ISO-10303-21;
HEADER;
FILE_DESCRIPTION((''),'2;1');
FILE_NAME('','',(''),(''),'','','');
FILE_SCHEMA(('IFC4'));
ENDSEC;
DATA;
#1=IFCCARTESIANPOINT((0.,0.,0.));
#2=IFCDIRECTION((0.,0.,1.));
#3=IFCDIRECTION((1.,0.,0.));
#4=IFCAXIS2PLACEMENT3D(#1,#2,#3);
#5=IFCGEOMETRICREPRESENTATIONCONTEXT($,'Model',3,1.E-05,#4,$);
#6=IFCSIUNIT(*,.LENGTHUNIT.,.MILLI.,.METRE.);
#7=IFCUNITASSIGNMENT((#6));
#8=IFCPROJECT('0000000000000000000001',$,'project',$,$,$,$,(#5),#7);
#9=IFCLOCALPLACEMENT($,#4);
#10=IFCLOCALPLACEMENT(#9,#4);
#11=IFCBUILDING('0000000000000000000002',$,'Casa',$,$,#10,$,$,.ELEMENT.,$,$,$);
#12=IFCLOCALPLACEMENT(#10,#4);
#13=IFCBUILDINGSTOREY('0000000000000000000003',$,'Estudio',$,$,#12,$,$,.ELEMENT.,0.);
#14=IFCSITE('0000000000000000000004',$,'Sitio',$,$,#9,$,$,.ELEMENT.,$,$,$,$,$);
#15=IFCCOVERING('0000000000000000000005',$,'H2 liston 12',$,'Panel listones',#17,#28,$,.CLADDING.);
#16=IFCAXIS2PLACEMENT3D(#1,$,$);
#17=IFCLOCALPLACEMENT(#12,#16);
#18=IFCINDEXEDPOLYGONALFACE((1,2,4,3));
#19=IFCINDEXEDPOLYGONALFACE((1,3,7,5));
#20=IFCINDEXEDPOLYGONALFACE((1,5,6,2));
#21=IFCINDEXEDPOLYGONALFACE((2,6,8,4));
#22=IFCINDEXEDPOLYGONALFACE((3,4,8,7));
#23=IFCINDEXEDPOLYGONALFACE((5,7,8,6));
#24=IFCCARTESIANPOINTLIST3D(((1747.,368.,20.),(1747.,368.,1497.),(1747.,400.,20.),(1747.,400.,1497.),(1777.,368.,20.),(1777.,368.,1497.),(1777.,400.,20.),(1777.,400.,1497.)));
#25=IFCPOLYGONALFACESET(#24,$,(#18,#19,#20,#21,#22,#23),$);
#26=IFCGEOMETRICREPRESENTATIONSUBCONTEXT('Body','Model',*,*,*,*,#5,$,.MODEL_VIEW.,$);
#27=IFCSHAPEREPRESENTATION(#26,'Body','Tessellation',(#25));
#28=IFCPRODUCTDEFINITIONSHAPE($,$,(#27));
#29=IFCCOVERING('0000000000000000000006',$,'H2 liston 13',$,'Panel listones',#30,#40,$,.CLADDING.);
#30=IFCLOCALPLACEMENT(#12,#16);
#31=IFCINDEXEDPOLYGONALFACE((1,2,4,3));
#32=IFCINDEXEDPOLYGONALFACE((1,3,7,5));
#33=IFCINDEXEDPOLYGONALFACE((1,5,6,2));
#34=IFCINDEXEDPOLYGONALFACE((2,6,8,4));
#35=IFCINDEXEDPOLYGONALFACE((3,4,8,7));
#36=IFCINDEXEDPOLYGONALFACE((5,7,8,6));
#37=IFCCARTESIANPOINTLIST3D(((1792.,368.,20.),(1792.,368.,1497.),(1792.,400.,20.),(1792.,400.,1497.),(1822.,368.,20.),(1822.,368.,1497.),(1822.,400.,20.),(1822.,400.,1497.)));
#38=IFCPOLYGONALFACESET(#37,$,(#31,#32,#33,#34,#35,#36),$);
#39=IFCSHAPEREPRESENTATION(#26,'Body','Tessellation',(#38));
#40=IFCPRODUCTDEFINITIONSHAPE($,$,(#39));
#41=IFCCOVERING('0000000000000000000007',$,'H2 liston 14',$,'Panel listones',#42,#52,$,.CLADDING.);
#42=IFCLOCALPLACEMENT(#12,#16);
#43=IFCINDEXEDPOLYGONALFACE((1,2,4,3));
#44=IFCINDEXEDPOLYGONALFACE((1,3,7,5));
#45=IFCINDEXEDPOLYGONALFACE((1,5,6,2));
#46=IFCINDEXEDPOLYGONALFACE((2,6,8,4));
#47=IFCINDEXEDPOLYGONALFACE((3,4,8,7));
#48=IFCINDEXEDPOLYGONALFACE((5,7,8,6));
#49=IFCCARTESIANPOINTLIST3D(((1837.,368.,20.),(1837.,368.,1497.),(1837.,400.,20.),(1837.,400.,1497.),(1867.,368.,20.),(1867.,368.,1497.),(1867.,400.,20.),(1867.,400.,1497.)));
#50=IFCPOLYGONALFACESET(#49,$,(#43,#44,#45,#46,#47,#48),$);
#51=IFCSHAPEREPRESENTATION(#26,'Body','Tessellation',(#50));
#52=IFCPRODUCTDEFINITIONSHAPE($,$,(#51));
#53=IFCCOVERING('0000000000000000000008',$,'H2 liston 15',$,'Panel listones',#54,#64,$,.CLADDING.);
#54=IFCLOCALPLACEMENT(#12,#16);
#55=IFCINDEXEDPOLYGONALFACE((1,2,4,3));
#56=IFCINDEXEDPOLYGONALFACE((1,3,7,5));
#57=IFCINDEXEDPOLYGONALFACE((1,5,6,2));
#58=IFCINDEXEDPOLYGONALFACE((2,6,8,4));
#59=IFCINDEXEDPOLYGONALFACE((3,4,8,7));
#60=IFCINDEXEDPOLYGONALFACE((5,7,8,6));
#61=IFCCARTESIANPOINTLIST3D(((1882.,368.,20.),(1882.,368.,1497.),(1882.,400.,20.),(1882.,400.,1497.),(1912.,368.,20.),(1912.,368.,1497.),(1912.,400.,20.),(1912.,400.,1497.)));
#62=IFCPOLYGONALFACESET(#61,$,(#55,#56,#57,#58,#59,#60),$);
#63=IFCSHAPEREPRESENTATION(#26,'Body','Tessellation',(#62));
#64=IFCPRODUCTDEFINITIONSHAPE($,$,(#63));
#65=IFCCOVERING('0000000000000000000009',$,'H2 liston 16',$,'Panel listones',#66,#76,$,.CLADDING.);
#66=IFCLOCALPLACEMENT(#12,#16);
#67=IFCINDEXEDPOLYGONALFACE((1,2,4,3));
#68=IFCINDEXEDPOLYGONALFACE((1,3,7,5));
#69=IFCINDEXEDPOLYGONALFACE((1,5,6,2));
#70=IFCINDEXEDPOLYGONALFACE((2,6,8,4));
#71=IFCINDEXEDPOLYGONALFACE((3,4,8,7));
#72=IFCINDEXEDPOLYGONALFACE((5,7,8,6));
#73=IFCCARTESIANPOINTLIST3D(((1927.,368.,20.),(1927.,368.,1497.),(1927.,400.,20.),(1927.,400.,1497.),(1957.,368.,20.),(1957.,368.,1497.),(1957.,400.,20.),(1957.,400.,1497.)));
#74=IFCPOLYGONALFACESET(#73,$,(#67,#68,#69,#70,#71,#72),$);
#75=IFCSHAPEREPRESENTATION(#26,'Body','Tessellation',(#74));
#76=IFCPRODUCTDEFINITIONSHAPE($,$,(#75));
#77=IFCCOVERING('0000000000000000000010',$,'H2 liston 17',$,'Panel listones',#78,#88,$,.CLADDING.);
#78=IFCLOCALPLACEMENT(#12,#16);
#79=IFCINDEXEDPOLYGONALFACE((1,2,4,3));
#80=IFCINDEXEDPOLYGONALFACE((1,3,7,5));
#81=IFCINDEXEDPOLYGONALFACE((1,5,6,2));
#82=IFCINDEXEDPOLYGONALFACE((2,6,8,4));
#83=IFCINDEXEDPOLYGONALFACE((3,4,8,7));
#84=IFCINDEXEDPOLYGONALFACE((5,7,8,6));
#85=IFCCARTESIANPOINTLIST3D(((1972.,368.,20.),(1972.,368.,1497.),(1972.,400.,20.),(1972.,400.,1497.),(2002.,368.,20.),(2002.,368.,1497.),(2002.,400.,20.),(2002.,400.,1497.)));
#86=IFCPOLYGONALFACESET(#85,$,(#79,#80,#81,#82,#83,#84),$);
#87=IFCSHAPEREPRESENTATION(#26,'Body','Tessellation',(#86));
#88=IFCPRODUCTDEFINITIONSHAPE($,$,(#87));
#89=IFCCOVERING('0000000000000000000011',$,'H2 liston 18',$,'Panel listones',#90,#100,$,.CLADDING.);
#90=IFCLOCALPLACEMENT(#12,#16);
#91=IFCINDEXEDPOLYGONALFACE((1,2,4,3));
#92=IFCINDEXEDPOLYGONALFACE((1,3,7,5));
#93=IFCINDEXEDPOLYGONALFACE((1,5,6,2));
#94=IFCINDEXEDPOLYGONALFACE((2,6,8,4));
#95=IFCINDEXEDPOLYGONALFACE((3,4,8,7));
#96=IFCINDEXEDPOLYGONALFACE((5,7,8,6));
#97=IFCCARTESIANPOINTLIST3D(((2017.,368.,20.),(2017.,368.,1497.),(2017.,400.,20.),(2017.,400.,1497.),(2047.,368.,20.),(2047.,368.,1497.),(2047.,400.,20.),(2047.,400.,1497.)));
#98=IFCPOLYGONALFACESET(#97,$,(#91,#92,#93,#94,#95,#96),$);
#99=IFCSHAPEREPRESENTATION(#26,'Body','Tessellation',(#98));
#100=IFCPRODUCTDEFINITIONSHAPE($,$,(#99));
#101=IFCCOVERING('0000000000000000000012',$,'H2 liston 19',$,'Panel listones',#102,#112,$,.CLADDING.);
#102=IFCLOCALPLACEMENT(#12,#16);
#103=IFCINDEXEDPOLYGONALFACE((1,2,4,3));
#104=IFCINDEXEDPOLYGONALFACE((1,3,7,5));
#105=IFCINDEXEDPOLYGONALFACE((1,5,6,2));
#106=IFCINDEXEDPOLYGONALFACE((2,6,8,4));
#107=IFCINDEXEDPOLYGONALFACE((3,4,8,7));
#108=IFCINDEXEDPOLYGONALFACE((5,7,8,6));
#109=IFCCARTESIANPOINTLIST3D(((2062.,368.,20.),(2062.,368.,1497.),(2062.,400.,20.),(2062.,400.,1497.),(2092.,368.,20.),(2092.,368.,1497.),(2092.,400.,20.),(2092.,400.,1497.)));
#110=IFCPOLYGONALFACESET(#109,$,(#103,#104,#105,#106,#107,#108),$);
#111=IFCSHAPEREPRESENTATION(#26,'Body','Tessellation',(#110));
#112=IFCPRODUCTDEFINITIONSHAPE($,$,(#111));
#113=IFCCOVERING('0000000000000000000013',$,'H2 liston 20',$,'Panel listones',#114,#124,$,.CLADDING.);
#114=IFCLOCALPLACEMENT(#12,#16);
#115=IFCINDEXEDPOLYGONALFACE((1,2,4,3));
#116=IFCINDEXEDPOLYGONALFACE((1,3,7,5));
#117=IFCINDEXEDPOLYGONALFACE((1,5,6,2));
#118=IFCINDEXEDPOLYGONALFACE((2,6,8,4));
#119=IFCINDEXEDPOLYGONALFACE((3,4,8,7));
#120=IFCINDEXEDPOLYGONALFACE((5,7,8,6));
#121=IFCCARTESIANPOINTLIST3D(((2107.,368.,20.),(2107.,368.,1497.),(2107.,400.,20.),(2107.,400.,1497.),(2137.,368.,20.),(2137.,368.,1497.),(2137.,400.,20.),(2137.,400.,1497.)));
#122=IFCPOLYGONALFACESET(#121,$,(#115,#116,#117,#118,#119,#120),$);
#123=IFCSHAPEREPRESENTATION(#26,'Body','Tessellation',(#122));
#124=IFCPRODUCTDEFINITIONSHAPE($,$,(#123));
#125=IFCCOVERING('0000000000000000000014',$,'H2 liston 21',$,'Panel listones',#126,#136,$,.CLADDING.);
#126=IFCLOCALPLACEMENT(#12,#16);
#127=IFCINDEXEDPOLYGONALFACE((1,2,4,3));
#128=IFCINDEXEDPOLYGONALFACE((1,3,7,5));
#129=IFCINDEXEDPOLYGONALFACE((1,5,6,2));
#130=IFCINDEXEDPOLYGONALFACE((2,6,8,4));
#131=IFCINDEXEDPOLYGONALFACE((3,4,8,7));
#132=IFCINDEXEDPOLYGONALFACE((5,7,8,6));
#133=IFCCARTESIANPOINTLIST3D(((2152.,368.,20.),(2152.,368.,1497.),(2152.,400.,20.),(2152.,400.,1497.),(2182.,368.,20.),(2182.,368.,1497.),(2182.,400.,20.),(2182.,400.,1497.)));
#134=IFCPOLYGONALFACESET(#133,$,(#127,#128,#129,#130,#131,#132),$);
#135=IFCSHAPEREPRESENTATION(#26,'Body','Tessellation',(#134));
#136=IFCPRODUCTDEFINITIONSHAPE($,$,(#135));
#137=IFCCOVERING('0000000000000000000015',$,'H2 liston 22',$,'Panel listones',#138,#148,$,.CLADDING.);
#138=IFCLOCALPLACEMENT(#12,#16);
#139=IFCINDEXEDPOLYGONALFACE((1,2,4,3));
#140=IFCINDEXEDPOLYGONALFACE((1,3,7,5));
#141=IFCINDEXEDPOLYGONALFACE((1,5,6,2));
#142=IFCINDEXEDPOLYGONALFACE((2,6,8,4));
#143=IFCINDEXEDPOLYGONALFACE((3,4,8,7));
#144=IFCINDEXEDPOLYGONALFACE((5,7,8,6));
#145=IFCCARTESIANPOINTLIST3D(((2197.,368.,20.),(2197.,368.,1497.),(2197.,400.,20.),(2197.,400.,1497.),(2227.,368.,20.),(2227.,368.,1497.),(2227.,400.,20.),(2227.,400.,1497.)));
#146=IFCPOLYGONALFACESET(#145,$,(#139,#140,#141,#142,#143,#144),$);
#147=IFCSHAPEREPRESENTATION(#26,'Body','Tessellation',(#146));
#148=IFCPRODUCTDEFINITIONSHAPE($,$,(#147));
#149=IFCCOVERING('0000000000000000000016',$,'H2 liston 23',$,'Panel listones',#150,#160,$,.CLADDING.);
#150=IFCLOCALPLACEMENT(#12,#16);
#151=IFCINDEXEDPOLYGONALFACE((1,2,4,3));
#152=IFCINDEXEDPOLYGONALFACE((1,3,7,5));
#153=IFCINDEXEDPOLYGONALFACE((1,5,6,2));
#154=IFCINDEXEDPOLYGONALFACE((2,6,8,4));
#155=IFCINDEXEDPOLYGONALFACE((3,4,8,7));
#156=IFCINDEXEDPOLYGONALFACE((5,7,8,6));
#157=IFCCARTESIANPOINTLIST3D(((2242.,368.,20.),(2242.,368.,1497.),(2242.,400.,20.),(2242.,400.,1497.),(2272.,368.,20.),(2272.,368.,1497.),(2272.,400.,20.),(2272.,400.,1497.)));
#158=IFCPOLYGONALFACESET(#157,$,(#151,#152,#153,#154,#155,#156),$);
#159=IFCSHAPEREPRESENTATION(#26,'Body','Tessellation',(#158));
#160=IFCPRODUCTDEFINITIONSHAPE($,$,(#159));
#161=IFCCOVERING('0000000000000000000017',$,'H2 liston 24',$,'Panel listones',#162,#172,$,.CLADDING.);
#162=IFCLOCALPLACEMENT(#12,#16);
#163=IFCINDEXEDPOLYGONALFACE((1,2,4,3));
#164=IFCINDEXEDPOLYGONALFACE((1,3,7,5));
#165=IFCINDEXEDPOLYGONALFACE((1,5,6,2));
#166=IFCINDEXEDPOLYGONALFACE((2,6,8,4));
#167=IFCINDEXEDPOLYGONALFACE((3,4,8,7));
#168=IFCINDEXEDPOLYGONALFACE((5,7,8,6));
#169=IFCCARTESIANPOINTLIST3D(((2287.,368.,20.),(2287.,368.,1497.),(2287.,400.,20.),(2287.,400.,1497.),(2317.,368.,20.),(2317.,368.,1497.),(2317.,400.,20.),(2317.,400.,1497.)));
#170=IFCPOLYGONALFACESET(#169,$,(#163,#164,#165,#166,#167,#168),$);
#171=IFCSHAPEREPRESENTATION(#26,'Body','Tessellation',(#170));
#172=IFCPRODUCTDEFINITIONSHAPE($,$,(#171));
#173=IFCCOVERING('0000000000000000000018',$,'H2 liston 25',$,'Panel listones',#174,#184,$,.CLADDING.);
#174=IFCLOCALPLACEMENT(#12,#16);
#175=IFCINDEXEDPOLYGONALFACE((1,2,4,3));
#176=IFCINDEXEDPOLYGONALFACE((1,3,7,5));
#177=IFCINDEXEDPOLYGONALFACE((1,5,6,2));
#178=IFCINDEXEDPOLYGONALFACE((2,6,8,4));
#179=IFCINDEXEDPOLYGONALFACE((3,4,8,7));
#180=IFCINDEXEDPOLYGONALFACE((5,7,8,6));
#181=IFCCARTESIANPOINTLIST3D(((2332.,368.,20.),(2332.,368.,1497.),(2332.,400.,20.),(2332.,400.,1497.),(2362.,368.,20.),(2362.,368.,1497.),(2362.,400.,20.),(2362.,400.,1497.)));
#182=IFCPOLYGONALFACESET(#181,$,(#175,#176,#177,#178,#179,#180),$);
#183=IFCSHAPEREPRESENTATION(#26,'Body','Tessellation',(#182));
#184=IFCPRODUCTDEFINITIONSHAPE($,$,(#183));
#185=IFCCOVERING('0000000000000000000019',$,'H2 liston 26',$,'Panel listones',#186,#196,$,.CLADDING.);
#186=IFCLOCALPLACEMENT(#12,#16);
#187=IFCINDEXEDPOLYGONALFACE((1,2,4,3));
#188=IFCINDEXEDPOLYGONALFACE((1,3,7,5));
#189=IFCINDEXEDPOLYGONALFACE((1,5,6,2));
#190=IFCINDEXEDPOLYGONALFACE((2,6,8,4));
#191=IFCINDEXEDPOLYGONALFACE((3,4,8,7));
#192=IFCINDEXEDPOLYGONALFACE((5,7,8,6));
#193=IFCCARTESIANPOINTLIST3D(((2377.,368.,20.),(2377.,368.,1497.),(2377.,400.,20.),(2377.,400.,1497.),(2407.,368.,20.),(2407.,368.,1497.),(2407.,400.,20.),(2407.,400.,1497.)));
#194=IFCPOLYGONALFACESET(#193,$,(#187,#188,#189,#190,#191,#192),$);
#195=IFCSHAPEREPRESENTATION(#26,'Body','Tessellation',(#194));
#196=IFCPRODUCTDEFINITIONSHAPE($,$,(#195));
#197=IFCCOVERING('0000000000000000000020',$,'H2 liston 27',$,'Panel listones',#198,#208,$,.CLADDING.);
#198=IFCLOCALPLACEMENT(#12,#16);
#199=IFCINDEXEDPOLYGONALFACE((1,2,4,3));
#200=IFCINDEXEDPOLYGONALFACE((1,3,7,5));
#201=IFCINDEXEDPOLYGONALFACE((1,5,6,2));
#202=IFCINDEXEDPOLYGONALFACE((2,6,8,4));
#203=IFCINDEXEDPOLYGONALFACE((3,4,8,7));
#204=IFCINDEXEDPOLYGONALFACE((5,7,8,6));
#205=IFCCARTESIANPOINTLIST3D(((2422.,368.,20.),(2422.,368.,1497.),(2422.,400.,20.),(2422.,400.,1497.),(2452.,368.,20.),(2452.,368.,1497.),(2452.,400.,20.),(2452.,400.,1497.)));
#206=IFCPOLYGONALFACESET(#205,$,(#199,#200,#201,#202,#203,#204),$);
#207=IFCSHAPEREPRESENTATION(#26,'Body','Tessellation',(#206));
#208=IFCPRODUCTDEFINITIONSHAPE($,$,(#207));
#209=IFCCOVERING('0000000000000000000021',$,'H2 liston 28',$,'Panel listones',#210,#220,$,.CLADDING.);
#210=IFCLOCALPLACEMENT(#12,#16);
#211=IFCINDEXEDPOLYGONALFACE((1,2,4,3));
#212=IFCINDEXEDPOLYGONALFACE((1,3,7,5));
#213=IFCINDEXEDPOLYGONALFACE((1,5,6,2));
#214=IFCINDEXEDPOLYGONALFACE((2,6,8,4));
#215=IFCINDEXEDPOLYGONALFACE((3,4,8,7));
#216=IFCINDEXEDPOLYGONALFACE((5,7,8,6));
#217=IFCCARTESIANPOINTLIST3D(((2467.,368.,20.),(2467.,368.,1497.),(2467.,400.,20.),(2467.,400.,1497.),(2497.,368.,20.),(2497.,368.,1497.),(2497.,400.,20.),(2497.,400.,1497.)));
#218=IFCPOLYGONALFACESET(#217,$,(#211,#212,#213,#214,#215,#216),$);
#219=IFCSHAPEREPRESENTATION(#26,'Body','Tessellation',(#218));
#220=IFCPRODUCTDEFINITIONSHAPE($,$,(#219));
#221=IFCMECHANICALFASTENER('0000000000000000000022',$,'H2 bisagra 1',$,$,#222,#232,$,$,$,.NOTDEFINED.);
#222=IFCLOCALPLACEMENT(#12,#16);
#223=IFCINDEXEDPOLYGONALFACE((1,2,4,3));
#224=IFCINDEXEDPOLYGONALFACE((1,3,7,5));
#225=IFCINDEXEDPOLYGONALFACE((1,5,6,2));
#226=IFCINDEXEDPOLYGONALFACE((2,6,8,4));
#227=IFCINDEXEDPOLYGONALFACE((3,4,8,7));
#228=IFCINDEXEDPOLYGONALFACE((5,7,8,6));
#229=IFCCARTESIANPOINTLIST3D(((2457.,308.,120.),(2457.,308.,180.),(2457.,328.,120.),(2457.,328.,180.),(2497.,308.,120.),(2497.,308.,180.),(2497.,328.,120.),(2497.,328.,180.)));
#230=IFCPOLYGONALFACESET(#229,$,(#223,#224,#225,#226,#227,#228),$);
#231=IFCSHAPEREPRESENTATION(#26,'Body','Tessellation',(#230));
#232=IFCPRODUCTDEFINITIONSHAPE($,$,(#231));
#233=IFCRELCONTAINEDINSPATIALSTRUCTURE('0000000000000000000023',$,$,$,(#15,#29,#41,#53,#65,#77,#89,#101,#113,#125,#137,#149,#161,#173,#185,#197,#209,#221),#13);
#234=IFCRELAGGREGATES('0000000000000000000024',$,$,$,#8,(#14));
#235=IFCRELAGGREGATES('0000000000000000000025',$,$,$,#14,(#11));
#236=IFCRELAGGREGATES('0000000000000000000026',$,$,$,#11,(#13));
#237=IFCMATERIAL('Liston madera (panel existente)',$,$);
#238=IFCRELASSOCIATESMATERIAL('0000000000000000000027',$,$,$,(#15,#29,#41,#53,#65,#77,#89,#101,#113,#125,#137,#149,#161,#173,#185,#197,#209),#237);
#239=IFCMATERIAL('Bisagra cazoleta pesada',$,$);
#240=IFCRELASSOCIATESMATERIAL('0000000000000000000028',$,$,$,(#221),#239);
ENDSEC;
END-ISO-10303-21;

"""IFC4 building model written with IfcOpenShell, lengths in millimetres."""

from ifc_helpers import new_model, si_unit, frame, frame_2d, origin_with_axes, place, context, subcontext, project, spatial, rectangle, extrude, material, element, save


model = new_model("IFC4")

# Units and contexts
model_context = context("Model", 3, precision=1e-05, world=origin_with_axes())
body_context = subcontext(model_context, "Body", "Model", "MODEL_VIEW")
ifc_project = project(units=[si_unit("LENGTHUNIT", "METRE", prefix="MILLI")], contexts=[model_context])

# Site, building, storey
site_placement = place(None, origin_with_axes())
site = spatial("IfcSite", under=ifc_project, at=site_placement, Name="Sitio", CompositionType="ELEMENT")
building_placement = place(site_placement, origin_with_axes())
building = spatial("IfcBuilding", under=site, at=building_placement, Name="Casa", CompositionType="ELEMENT")
storey_placement = place(building_placement, origin_with_axes())
storey = spatial("IfcBuildingStorey", under=building, at=storey_placement, Name="Estudio", CompositionType="ELEMENT", Elevation=0.0)

# Coverings
ifc_material_1 = material(Name="Liston madera (panel existente)")
for number, where, z_axis, x_axis, name in (
    (1, (1747.0, 368.0, 20.0), (0.0, 0.0, 1.0), (1.0, 0.0, 0.0), "H2 liston 12"),
    (2, (1792.0, 368.0, 20.0), (0.0, 0.0, 1.0), (1.0, 0.0, 0.0), "H2 liston 13"),
    (3, (1837.0, 368.0, 20.0), (0.0, 0.0, 1.0), (1.0, 0.0, 0.0), "H2 liston 14"),
    (4, (1882.0, 368.0, 20.0), (0.0, 0.0, 1.0), (1.0, 0.0, 0.0), "H2 liston 15"),
    (5, (1927.0, 368.0, 20.0), (0.0, 0.0, 1.0), (1.0, 0.0, 0.0), "H2 liston 16"),
    (6, (1972.0, 368.0, 20.0), (0.0, 0.0, 1.0), (1.0, 0.0, 0.0), "H2 liston 17"),
    (7, (2017.0, 368.0, 20.0), (0.0, 0.0, 1.0), (1.0, 0.0, 0.0), "H2 liston 18"),
    (8, (2062.0, 368.0, 20.0), (0.0, 0.0, 1.0), (1.0, 0.0, 0.0), "H2 liston 19"),
    (9, (2107.0, 368.0, 20.0), (0.0, 0.0, 1.0), (1.0, 0.0, 0.0), "H2 liston 20"),
    (10, (2152.0, 368.0, 20.0), (0.0, 0.0, 1.0), (1.0, 0.0, 0.0), "H2 liston 21"),
    (11, (2197.0, 368.0, 20.0), (0.0, 0.0, 1.0), (1.0, 0.0, 0.0), "H2 liston 22"),
    (12, (2242.0, 368.0, 20.0), (0.0, 0.0, 1.0), (1.0, 0.0, 0.0), "H2 liston 23"),
    (13, (2287.0, 368.0, 20.0), (0.0, 0.0, 1.0), (1.0, 0.0, 0.0), "H2 liston 24"),
    (14, (2332.0, 368.0, 20.0), (0.0, 0.0, 1.0), (1.0, 0.0, 0.0), "H2 liston 25"),
    (15, (2377.0, 368.0, 20.0), (0.0, 0.0, 1.0), (1.0, 0.0, 0.0), "H2 liston 26"),
    (16, (2422.0, 368.0, 20.0), (0.0, 0.0, 1.0), (1.0, 0.0, 0.0), "H2 liston 27"),
    (17, (2467.0, 368.0, 20.0), (0.0, 0.0, 1.0), (1.0, 0.0, 0.0), "H2 liston 28"),
):
    element("IfcCovering", number, at=place(storey_placement, frame(where, z_axis=z_axis, x_axis=x_axis)), inside=storey, material=ifc_material_1, Name=name, ObjectType="Panel listones", PredefinedType="CLADDING", context=body_context, shape_type="SweptSolid", body=[
        extrude(rectangle(XDim=30.0, YDim=32.0, at=frame_2d((15.0, 16.0))), origin_with_axes(), (0.0, 0.0, 1.0), 1477.0),
    ])

# Mechanical fastener
ifc_material_2 = material(Name="Bisagra cazoleta pesada")
mechanical_fastener_placement = place(storey_placement, frame((2457.0, 308.0, 120.0), z_axis=(0.0, 0.0, 1.0), x_axis=(1.0, 0.0, 0.0)))
element("IfcMechanicalFastener", 18, at=mechanical_fastener_placement, inside=storey, material=ifc_material_2, Name="H2 bisagra 1", PredefinedType="NOTDEFINED", context=body_context, shape_type="SweptSolid", body=[
    extrude(rectangle(XDim=40.0, YDim=20.0, at=frame_2d((20.0, 10.0))), origin_with_axes(), (0.0, 0.0, 1.0), 60.0),
])

save(model, "model.ifc")
